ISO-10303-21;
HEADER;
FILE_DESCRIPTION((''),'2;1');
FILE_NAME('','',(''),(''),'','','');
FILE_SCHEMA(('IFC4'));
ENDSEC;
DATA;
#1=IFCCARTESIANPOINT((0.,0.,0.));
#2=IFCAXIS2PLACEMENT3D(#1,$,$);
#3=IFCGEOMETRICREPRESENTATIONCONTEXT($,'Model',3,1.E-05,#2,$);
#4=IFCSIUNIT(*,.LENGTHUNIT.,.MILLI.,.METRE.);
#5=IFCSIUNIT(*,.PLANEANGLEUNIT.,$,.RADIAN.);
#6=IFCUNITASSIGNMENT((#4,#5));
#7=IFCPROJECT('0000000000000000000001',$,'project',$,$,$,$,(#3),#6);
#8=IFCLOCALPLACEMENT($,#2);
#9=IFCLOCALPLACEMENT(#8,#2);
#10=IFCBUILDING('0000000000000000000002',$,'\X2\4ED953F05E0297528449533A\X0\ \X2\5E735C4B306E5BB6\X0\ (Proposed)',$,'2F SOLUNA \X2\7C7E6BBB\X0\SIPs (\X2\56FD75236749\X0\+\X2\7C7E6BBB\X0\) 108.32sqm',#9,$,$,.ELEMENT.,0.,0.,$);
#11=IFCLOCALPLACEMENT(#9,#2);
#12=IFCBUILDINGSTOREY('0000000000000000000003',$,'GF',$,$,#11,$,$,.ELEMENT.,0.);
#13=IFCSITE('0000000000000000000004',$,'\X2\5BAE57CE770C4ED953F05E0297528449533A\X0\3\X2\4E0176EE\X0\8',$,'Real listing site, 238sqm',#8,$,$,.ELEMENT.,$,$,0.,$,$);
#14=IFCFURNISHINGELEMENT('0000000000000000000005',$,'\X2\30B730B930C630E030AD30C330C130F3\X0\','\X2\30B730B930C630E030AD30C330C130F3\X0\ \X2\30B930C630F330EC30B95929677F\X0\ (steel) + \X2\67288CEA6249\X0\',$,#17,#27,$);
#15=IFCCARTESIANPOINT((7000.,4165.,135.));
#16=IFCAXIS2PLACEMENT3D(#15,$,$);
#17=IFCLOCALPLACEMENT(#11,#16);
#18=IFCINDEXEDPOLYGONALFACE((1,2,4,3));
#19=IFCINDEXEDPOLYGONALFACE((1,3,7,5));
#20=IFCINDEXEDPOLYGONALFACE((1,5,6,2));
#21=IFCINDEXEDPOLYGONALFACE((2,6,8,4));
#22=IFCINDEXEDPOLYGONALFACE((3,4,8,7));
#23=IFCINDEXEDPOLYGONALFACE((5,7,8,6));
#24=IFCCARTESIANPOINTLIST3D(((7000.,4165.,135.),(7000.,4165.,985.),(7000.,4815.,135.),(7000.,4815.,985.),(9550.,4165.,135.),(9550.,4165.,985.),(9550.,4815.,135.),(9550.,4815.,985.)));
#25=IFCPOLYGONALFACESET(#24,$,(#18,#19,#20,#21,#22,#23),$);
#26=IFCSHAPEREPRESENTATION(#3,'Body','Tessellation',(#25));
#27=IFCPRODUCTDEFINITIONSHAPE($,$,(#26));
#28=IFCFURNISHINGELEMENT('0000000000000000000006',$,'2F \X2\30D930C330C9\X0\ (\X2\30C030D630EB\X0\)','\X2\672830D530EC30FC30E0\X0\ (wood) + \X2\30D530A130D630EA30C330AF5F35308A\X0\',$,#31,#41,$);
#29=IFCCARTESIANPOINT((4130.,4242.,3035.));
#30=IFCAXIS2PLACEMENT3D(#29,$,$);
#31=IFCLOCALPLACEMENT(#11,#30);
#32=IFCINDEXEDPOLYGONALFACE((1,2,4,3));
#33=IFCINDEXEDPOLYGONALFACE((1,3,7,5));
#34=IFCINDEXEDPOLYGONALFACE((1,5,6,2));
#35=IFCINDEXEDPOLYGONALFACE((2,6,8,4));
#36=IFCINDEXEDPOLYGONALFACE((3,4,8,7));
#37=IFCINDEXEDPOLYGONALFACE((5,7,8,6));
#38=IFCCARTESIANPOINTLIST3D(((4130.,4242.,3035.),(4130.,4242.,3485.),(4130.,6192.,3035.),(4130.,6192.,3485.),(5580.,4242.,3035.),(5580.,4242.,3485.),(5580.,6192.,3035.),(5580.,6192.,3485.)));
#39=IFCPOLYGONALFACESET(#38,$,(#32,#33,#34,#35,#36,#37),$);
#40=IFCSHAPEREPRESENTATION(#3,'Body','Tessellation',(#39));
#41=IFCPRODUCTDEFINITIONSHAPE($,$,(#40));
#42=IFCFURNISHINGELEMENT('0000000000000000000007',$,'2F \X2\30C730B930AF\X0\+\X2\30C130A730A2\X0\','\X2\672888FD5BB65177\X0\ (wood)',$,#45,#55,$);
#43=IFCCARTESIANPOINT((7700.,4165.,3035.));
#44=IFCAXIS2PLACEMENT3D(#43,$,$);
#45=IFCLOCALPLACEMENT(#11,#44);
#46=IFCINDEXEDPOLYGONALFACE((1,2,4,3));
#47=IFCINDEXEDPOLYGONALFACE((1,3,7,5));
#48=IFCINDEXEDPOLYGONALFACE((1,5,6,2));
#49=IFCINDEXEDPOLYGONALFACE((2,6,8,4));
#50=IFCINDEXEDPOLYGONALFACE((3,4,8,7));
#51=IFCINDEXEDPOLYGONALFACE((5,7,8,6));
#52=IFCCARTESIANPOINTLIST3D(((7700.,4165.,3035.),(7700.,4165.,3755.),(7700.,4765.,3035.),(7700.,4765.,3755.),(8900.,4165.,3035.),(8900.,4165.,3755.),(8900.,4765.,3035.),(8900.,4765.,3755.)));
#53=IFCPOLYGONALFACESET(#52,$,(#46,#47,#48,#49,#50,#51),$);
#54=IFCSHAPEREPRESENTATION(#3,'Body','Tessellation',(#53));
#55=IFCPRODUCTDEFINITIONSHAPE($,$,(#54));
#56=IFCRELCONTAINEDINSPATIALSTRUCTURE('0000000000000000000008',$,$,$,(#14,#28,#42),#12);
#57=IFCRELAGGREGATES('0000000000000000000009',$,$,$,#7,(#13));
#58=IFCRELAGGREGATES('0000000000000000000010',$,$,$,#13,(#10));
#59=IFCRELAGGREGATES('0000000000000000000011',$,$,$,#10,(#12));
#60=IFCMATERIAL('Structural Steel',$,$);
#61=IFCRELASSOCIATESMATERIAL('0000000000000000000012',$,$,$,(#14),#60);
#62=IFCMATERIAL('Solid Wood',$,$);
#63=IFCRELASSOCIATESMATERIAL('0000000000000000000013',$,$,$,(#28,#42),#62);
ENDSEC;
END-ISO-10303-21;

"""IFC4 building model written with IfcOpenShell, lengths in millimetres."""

from ifc_helpers import new_model, si_unit, frame, frame_2d, origin, place, context, project, spatial, rectangle, extrude, material, element, save


model = new_model("IFC4")

# Units and contexts
model_context = context("Model", 3, precision=1e-05, world=origin())
ifc_project = project(units=[si_unit("LENGTHUNIT", "METRE", prefix="MILLI"), si_unit("PLANEANGLEUNIT", "RADIAN")], contexts=[model_context])

# Site, building, storey
site_placement = place(None, origin())
site = spatial("IfcSite", under=ifc_project, at=site_placement, Name="宮城県仙台市青葉区3丁目8", ObjectType="Real listing site, 238sqm", CompositionType="ELEMENT", RefElevation=0.0)
building_placement = place(site_placement, origin())
building = spatial("IfcBuilding", under=site, at=building_placement, Name="仙台市青葉区 平屋の家 (Proposed)", ObjectType="2F SOLUNA 籾殻SIPs (国産杉+籾殻) 108.32sqm", CompositionType="ELEMENT", ElevationOfRefHeight=0.0, ElevationOfTerrain=0.0)
storey_placement = place(building_placement, origin())
storey = spatial("IfcBuildingStorey", under=building, at=storey_placement, Name="GF", CompositionType="ELEMENT", Elevation=0.0)

# Shared definitions
ifc_material_1 = material(Name="Solid Wood")

# Furnishing elements
ifc_material_2 = material(Name="Structural Steel")
furnishing_1_placement = place(storey_placement, frame((7000.0, 4165.0, 135.0)))
element("IfcFurnishingElement", 1, at=furnishing_1_placement, inside=storey, material=ifc_material_2, Name="システムキッチン", Description="システムキッチン ステンレス天板 (steel) + 木質扉", context=model_context, shape_type="SweptSolid", body=[
    extrude(rectangle(XDim=2550.0, YDim=650.0, at=frame_2d((1275.0, 325.0))), frame((7000.0, 4165.0, 135.0)), (0.0, 0.0, 1.0), 850.0),
])
furnishing_2_placement = place(storey_placement, frame((4130.0, 4242.0, 3035.0)))
element("IfcFurnishingElement", 2, at=furnishing_2_placement, inside=storey, material=ifc_material_1, Name="2F ベッド (ダブル)", Description="木フレーム (wood) + ファブリック張り", context=model_context, shape_type="SweptSolid", body=[
    extrude(rectangle(XDim=1450.0, YDim=1950.0, at=frame_2d((725.0, 975.0))), frame((4130.0, 4242.0, 3035.0)), (0.0, 0.0, 1.0), 450.0),
])
furnishing_3_placement = place(storey_placement, frame((7700.0, 4165.0, 3035.0)))
element("IfcFurnishingElement", 3, at=furnishing_3_placement, inside=storey, material=ifc_material_1, Name="2F デスク+チェア", Description="木製家具 (wood)", context=model_context, shape_type="SweptSolid", body=[
    extrude(rectangle(XDim=1200.0, YDim=600.0, at=frame_2d((600.0, 300.0))), frame((7700.0, 4165.0, 3035.0)), (0.0, 0.0, 1.0), 720.0),
])

save(model, "model.ifc")
